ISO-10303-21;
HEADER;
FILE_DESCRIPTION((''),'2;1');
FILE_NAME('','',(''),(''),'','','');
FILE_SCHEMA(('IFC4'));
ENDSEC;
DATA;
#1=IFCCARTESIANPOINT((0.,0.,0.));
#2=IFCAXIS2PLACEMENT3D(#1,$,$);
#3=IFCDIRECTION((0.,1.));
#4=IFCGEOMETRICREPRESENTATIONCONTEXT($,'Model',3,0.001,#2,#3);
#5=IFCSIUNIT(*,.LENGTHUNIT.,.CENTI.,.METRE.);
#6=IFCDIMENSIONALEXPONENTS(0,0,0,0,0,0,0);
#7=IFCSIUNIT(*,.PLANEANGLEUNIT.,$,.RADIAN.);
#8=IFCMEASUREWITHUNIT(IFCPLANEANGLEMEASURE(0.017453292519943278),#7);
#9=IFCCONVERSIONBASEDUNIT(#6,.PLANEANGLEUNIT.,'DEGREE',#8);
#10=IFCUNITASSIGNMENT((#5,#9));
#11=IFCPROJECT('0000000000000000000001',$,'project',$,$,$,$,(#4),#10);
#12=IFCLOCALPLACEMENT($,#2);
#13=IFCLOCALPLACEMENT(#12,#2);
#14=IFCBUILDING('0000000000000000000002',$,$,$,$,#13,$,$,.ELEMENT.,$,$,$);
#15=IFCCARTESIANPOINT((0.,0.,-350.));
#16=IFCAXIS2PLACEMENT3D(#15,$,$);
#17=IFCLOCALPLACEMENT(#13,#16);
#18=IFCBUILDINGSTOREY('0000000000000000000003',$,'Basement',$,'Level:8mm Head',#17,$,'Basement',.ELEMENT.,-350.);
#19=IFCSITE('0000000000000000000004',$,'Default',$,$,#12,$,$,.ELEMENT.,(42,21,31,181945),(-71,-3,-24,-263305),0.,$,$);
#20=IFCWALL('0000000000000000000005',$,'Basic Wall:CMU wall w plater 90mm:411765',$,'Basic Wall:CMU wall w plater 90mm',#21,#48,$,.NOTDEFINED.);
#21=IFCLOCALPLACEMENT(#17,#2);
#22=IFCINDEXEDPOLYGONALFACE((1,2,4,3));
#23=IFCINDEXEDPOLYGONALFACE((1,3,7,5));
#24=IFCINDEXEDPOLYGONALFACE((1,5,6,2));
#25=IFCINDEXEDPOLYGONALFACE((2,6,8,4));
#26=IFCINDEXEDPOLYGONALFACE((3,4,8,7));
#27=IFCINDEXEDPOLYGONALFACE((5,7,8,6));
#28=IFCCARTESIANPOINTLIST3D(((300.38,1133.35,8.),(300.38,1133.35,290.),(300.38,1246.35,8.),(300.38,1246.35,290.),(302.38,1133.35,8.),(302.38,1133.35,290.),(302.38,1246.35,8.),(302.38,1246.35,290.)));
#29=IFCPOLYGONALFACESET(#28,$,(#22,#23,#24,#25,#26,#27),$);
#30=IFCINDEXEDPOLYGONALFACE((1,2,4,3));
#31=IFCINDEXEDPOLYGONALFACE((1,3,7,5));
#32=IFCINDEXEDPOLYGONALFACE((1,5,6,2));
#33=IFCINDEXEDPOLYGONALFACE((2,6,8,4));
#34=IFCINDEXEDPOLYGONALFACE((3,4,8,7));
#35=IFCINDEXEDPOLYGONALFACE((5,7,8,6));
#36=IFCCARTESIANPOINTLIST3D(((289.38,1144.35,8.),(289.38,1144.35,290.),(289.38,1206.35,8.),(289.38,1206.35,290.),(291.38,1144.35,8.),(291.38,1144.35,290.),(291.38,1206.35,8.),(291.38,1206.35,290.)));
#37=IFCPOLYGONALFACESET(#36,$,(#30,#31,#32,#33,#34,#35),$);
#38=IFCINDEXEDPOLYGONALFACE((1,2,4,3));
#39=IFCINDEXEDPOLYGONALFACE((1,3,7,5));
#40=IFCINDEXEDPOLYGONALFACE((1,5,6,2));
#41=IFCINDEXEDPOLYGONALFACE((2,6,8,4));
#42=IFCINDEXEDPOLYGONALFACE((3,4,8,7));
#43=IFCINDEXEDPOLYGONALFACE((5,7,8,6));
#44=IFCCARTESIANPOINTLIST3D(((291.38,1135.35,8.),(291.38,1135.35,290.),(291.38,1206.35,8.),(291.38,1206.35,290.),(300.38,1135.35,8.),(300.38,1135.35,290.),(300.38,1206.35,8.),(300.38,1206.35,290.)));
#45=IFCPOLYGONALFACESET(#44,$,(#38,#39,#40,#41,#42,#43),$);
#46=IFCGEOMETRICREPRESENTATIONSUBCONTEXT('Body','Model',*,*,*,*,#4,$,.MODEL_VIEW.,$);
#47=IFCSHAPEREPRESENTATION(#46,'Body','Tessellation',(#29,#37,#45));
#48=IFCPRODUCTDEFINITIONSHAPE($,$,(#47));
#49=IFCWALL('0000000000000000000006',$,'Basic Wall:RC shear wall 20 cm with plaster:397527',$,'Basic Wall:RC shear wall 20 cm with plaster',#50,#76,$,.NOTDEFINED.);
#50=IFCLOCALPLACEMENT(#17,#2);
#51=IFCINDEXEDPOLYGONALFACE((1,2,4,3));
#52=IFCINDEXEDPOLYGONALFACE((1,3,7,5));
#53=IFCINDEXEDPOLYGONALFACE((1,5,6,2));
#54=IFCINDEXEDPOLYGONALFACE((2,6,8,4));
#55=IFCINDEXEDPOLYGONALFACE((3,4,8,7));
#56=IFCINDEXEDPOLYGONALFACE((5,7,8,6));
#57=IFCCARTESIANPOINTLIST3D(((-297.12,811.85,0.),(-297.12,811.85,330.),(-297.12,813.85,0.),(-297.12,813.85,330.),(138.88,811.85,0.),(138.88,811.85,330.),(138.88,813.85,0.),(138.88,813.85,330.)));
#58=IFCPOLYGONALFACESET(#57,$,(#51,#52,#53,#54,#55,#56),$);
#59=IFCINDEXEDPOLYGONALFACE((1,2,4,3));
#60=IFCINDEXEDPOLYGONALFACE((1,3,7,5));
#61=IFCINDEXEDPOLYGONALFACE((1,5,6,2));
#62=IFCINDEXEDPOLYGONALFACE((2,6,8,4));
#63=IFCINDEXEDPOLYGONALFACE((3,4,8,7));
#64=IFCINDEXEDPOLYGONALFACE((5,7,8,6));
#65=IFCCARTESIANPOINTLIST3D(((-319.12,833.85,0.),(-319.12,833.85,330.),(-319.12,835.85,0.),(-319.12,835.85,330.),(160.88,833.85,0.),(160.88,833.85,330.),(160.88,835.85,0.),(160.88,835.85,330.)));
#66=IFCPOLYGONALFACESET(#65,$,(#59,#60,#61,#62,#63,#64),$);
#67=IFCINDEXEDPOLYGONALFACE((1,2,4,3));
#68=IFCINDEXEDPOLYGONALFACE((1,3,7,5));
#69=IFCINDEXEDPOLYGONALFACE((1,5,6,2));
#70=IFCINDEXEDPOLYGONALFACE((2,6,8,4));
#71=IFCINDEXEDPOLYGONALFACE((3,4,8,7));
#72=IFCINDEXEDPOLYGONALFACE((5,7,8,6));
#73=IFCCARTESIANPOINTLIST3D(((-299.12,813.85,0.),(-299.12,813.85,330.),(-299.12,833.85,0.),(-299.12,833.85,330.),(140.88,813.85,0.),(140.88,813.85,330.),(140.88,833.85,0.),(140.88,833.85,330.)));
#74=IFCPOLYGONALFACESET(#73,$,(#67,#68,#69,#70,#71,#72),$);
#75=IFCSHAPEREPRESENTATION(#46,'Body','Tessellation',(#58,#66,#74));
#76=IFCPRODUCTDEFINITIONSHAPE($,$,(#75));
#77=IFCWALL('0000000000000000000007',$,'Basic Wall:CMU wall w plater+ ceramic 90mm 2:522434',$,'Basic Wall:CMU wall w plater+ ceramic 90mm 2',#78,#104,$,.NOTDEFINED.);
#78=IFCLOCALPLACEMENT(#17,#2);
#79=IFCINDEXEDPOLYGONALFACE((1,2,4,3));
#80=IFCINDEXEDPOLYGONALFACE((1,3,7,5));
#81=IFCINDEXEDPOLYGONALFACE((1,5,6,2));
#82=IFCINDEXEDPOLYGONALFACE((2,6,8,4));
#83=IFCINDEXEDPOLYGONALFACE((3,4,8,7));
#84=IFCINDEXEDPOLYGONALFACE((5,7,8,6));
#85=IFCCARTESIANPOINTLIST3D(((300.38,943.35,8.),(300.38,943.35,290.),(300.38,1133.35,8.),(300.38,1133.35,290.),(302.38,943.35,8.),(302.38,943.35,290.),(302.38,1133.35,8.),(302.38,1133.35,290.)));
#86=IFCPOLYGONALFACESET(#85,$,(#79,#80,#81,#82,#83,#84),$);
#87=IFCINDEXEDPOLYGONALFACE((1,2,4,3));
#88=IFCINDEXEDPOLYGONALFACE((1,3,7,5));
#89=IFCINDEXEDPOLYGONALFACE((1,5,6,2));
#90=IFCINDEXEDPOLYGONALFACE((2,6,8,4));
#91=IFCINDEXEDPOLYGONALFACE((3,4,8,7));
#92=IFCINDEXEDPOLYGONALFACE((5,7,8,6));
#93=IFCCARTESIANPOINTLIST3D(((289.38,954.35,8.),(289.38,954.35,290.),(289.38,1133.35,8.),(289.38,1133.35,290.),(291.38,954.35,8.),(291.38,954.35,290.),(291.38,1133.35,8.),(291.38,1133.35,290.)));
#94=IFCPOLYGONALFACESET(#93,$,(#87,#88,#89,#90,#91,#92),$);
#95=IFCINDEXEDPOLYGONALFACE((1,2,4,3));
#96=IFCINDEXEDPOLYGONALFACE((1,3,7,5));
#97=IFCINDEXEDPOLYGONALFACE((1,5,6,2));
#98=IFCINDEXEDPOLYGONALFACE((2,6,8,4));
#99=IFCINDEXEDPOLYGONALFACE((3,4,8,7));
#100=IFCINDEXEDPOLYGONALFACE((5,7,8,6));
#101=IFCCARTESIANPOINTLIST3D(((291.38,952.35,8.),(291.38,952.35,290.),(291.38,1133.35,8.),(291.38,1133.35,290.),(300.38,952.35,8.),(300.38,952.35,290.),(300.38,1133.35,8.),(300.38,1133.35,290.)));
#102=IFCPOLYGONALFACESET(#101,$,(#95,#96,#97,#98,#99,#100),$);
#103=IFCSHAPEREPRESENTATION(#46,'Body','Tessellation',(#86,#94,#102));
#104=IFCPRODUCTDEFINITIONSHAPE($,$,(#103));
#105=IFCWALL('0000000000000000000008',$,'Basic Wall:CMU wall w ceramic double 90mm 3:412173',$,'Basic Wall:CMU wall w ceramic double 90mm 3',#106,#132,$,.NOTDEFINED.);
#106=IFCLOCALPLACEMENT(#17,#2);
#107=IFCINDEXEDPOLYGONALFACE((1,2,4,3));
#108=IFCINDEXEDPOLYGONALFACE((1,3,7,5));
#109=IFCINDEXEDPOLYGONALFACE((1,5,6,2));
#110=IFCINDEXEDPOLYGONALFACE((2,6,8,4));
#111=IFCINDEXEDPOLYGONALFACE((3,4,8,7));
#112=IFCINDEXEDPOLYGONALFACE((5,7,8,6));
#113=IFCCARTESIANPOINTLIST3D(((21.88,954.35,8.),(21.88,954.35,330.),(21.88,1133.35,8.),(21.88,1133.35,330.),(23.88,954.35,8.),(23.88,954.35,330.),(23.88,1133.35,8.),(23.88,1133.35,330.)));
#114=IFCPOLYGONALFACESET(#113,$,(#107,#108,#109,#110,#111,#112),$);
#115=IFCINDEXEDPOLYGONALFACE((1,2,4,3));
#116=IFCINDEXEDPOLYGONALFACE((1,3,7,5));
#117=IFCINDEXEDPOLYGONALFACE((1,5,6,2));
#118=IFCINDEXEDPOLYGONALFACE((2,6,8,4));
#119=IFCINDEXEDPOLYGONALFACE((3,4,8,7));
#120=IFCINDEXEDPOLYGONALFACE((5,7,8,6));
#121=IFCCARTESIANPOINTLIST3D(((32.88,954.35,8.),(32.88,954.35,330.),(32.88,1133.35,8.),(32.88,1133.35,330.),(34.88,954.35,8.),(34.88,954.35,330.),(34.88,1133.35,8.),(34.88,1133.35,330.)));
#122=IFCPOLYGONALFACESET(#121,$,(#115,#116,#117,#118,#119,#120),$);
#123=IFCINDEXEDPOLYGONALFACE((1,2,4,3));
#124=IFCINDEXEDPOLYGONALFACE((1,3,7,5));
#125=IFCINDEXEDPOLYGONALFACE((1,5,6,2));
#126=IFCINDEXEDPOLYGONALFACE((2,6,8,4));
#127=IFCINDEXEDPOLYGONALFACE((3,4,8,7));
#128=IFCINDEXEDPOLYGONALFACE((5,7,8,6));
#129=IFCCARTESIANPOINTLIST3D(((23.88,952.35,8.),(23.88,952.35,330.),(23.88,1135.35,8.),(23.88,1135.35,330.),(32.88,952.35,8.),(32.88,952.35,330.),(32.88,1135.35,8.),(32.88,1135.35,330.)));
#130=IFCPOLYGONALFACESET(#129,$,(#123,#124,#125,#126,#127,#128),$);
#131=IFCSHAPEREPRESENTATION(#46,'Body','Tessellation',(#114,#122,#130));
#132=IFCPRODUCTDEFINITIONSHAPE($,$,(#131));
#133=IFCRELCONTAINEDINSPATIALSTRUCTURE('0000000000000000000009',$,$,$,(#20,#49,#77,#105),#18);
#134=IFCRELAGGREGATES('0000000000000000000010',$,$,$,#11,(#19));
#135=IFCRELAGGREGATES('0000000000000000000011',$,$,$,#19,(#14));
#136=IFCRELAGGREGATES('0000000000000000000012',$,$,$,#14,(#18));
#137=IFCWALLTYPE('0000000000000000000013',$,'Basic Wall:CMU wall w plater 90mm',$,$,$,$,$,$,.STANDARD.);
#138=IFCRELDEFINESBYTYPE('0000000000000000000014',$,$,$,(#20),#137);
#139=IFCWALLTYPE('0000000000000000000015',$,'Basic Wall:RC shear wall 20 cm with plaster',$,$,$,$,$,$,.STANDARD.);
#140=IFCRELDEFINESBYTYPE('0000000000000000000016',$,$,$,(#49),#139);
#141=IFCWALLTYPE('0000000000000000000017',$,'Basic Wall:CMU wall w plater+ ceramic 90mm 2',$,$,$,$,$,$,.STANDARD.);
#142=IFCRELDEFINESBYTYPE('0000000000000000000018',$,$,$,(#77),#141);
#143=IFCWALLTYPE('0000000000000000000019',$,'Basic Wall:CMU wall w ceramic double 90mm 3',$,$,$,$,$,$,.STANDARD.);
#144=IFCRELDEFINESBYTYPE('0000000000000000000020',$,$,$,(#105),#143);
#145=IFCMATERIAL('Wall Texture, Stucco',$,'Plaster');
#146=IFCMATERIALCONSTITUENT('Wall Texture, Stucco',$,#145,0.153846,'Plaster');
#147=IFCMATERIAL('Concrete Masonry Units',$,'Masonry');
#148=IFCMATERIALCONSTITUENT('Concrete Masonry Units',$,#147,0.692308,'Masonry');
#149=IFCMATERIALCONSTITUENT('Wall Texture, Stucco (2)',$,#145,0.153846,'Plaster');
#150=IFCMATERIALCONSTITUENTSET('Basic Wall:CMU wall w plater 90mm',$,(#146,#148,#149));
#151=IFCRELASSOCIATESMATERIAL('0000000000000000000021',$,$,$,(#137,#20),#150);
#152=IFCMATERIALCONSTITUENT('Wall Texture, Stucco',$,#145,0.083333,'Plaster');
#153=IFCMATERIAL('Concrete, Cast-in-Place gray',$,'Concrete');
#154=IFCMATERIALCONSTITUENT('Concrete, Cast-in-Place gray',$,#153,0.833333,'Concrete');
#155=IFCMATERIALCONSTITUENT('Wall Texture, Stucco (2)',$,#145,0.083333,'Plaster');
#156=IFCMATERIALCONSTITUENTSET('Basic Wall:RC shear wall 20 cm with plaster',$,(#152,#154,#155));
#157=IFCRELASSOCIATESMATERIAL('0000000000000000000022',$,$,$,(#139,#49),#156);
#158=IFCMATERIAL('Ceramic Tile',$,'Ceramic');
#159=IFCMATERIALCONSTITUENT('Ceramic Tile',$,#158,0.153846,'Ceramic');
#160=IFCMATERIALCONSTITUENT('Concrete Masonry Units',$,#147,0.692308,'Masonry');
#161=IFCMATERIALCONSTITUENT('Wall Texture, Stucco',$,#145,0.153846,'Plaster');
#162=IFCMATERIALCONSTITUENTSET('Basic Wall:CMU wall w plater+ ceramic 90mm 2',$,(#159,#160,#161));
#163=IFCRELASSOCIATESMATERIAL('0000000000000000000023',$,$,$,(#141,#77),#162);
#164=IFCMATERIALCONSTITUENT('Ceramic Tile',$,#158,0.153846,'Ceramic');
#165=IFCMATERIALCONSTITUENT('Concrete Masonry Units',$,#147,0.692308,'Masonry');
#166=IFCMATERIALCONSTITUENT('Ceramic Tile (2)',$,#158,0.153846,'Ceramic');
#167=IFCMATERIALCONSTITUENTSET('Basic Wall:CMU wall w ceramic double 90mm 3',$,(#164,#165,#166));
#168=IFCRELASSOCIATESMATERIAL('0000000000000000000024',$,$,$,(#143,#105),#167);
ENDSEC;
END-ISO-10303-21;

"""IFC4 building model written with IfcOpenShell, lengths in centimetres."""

from ifc_helpers import new_model, entity, si_unit, converted_unit, direction, frame, origin, place, context, subcontext, project, spatial, indexed_curve, outline, extrude, material, constituent, constituent_set, type_object, element, save


model = new_model("IFC4")

# Units and contexts
model_context = context("Model", 3, precision=0.001, world=origin(), true_north=direction((0.0, 1.0)))
body_context = subcontext(model_context, "Body", "Model", "MODEL_VIEW")
ifc_project = project(units=[si_unit("LENGTHUNIT", "METRE", prefix="CENTI"), converted_unit("PLANEANGLEUNIT", "DEGREE", entity("IfcPlaneAngleMeasure", 0.017453292519943278), si_unit("PLANEANGLEUNIT", "RADIAN"), dimensions=[0, 0, 0, 0, 0, 0, 0])], contexts=[model_context])

# Site, building, storey
site_placement = place(None, origin())
site = spatial("IfcSite", under=ifc_project, at=site_placement, Name="Default", CompositionType="ELEMENT", RefLatitude=(42, 21, 31, 181945), RefLongitude=(-71, -3, -24, -263305), RefElevation=0.0)
building_placement = place(site_placement, origin())
building = spatial("IfcBuilding", under=site, at=building_placement, CompositionType="ELEMENT")
storey_placement = place(building_placement, frame((0.0, 0.0, -350.0)))
storey = spatial("IfcBuildingStorey", under=building, at=storey_placement, Name="Basement", ObjectType="Level:8mm Head", LongName="Basement", CompositionType="ELEMENT", Elevation=-350.0)

# Shared definitions
ifc_material_1 = material(Name="Concrete, Cast-in-Place gray", Category="Concrete")

# Shared definitions
ifc_material_2 = material(Name="Ceramic Tile", Category="Ceramic")

# Wall
ifc_material_3 = material(Name="Wall Texture, Stucco", Category="Plaster")
ifc_constituent_1 = constituent(ifc_material_3, Name="Wall Texture, Stucco", Category="Plaster", fraction=0.153846)
ifc_material_4 = material(Name="Concrete Masonry Units", Category="Masonry")
ifc_constituent_2 = constituent(ifc_material_4, Name="Concrete Masonry Units", Category="Masonry", fraction=0.692308)
ifc_constituent_3 = constituent(ifc_material_3, Name="Wall Texture, Stucco (2)", Category="Plaster", fraction=0.153846)
ifc_constituent_set_1 = constituent_set(constituents=[ifc_constituent_1, ifc_constituent_2, ifc_constituent_3], Name="Basic Wall:CMU wall w plater 90mm")
wall_type_1 = type_object("IfcWallType", Name="Basic Wall:CMU wall w plater 90mm", PredefinedType="STANDARD", material=ifc_constituent_set_1)
wall_1_placement = place(storey_placement, frame((295.88, 1133.35, 8.0), z_axis=(0.0, 0.0, 1.0), x_axis=(0.0, 1.0, 0.0)))
element("IfcWall", 1, at=wall_1_placement, inside=storey, type_object=wall_type_1, material=ifc_constituent_set_1, Name="Basic Wall:CMU wall w plater 90mm:411765", ObjectType="Basic Wall:CMU wall w plater 90mm", PredefinedType="NOTDEFINED", context=body_context, shape_type="SweptSolid", body=[
    extrude(outline(indexed_curve([(-1.0, -56.5), (1.0, -56.5), (1.0, 56.5), (-1.0, 56.5), (-1.0, -56.5)], self_intersect=False)), frame((56.5, -5.5, 0.0), z_axis=(0.0, 0.0, 1.0), x_axis=(0.0, 1.0, 0.0)), (0.0, 0.0, 1.0), 282.0),
    extrude(outline(indexed_curve([(-1.0, -31.0), (1.0, -31.0), (1.0, 31.0), (-1.0, 31.0), (-1.0, -31.0)], self_intersect=False)), frame((42.0, 5.5, 0.0), z_axis=(0.0, 0.0, 1.0), x_axis=(0.0, -1.0, 0.0)), (0.0, 0.0, 1.0), 282.0),
    extrude(outline(indexed_curve([(-35.5, -4.5), (35.5, -4.5), (35.5, 4.5), (-35.5, 4.5), (-35.5, -4.5)], self_intersect=False)), frame((37.5, 0.0, 0.0)), (0.0, 0.0, 1.0), 282.0),
])

# Shared definitions
ifc_constituent_4 = constituent(ifc_material_3, Name="Wall Texture, Stucco", Category="Plaster", fraction=0.083333)
ifc_constituent_5 = constituent(ifc_material_1, Name="Concrete, Cast-in-Place gray", Category="Concrete", fraction=0.833333)
ifc_constituent_6 = constituent(ifc_material_3, Name="Wall Texture, Stucco (2)", Category="Plaster", fraction=0.083333)
ifc_constituent_set_2 = constituent_set(constituents=[ifc_constituent_4, ifc_constituent_5, ifc_constituent_6], Name="Basic Wall:RC shear wall 20 cm with plaster")
wall_type_2 = type_object("IfcWallType", Name="Basic Wall:RC shear wall 20 cm with plaster", PredefinedType="STANDARD", material=ifc_constituent_set_2)

# Walls
wall_2_placement = place(storey_placement, frame((138.88, 823.85, 0.0), z_axis=(0.0, 0.0, 1.0), x_axis=(-1.0, 0.0, 0.0)))
element("IfcWall", 2, at=wall_2_placement, inside=storey, type_object=wall_type_2, material=ifc_constituent_set_2, Name="Basic Wall:RC shear wall 20 cm with plaster:397527", ObjectType="Basic Wall:RC shear wall 20 cm with plaster", PredefinedType="NOTDEFINED", context=body_context, shape_type="SweptSolid", body=[
    extrude(outline(indexed_curve([(-1.0, -218.0), (1.0, -218.0), (1.0, 218.0), (-1.0, 218.0), (-1.0, -218.0)], self_intersect=False)), frame((218.0, 11.0, 0.0), z_axis=(0.0, 0.0, 1.0), x_axis=(0.0, -1.0, 0.0)), (0.0, 0.0, 1.0), 330.0),
    extrude(outline(indexed_curve([(-165.0, -1.0), (165.0, -1.0), (165.0, 1.0), (-165.0, 1.0), (-165.0, -1.0)], self_intersect=False)), frame((458.0, -11.0, 165.0), z_axis=(-1.0, 0.0, 0.0), x_axis=(0.0, 0.0, 1.0)), (0.0, 0.0, 1.0), 480.0),
    extrude(outline(indexed_curve([(-220.0, -10.0), (220.0, -10.0), (220.0, 10.0), (-220.0, 10.0), (-220.0, -10.0)], self_intersect=False)), frame((218.0, 0.0, 0.0)), (0.0, 0.0, 1.0), 330.0),
])
ifc_constituent_7 = constituent(ifc_material_2, Name="Ceramic Tile", Category="Ceramic", fraction=0.153846)
ifc_constituent_8 = constituent(ifc_material_4, Name="Concrete Masonry Units", Category="Masonry", fraction=0.692308)
ifc_constituent_9 = constituent(ifc_material_3, Name="Wall Texture, Stucco", Category="Plaster", fraction=0.153846)
ifc_constituent_set_3 = constituent_set(constituents=[ifc_constituent_7, ifc_constituent_8, ifc_constituent_9], Name="Basic Wall:CMU wall w plater+ ceramic 90mm 2")
wall_type_3 = type_object("IfcWallType", Name="Basic Wall:CMU wall w plater+ ceramic 90mm 2", PredefinedType="STANDARD", material=ifc_constituent_set_3)
wall_3_placement = place(storey_placement, frame((295.88, 954.35, 8.0), z_axis=(0.0, 0.0, 1.0), x_axis=(0.0, 1.0, 0.0)))
element("IfcWall", 3, at=wall_3_placement, inside=storey, type_object=wall_type_3, material=ifc_constituent_set_3, Name="Basic Wall:CMU wall w plater+ ceramic 90mm 2:522434", ObjectType="Basic Wall:CMU wall w plater+ ceramic 90mm 2", PredefinedType="NOTDEFINED", context=body_context, shape_type="SweptSolid", body=[
    extrude(outline(indexed_curve([(-1.0, -95.0), (1.0, -95.0), (1.0, 95.0), (-1.0, 95.0), (-1.0, -95.0)], self_intersect=False)), frame((84.0, -5.5, 0.0), z_axis=(0.0, 0.0, 1.0), x_axis=(0.0, 1.0, 0.0)), (0.0, 0.0, 1.0), 282.0),
    extrude(outline(indexed_curve([(-1.0, -89.5), (1.0, -89.5), (1.0, 89.5), (-1.0, 89.5), (-1.0, -89.5)], self_intersect=False)), frame((89.5, 5.5, 0.0), z_axis=(0.0, 0.0, 1.0), x_axis=(0.0, -1.0, 0.0)), (0.0, 0.0, 1.0), 282.0),
    extrude(outline(indexed_curve([(-90.5, -4.5), (90.5, -4.5), (90.5, 4.5), (-90.5, 4.5), (-90.5, -4.5)], self_intersect=False)), frame((88.5, 0.0, 0.0)), (0.0, 0.0, 1.0), 282.0),
])
ifc_constituent_10 = constituent(ifc_material_2, Name="Ceramic Tile", Category="Ceramic", fraction=0.153846)
ifc_constituent_11 = constituent(ifc_material_4, Name="Concrete Masonry Units", Category="Masonry", fraction=0.692308)
ifc_constituent_12 = constituent(ifc_material_2, Name="Ceramic Tile (2)", Category="Ceramic", fraction=0.153846)
ifc_constituent_set_4 = constituent_set(constituents=[ifc_constituent_10, ifc_constituent_11, ifc_constituent_12], Name="Basic Wall:CMU wall w ceramic double 90mm 3")
wall_type_4 = type_object("IfcWallType", Name="Basic Wall:CMU wall w ceramic double 90mm 3", PredefinedType="STANDARD", material=ifc_constituent_set_4)
wall_4_placement = place(storey_placement, frame((28.38, 1133.35, 8.0), z_axis=(0.0, 0.0, 1.0), x_axis=(0.0, -1.0, 0.0)))
element("IfcWall", 4, at=wall_4_placement, inside=storey, type_object=wall_type_4, material=ifc_constituent_set_4, Name="Basic Wall:CMU wall w ceramic double 90mm 3:412173", ObjectType="Basic Wall:CMU wall w ceramic double 90mm 3", PredefinedType="NOTDEFINED", context=body_context, shape_type="SweptSolid", body=[
    extrude(outline(indexed_curve([(-1.0, -89.5), (1.0, -89.5), (1.0, 89.5), (-1.0, 89.5), (-1.0, -89.5)], self_intersect=False)), frame((89.5, -5.5, 0.0), z_axis=(0.0, 0.0, 1.0), x_axis=(0.0, 1.0, 0.0)), (0.0, 0.0, 1.0), 322.0),
    extrude(outline(indexed_curve([(-1.0, -89.5), (1.0, -89.5), (1.0, 89.5), (-1.0, 89.5), (-1.0, -89.5)], self_intersect=False)), frame((89.5, 5.5, 0.0), z_axis=(0.0, 0.0, 1.0), x_axis=(0.0, -1.0, 0.0)), (0.0, 0.0, 1.0), 322.0),
    extrude(outline(indexed_curve([(-91.5, -4.5), (91.5, -4.5), (91.5, 4.5), (-91.5, 4.5), (-91.5, -4.5)], self_intersect=False)), frame((89.5, 0.0, 0.0)), (0.0, 0.0, 1.0), 322.0),
])

save(model, "model.ifc")
